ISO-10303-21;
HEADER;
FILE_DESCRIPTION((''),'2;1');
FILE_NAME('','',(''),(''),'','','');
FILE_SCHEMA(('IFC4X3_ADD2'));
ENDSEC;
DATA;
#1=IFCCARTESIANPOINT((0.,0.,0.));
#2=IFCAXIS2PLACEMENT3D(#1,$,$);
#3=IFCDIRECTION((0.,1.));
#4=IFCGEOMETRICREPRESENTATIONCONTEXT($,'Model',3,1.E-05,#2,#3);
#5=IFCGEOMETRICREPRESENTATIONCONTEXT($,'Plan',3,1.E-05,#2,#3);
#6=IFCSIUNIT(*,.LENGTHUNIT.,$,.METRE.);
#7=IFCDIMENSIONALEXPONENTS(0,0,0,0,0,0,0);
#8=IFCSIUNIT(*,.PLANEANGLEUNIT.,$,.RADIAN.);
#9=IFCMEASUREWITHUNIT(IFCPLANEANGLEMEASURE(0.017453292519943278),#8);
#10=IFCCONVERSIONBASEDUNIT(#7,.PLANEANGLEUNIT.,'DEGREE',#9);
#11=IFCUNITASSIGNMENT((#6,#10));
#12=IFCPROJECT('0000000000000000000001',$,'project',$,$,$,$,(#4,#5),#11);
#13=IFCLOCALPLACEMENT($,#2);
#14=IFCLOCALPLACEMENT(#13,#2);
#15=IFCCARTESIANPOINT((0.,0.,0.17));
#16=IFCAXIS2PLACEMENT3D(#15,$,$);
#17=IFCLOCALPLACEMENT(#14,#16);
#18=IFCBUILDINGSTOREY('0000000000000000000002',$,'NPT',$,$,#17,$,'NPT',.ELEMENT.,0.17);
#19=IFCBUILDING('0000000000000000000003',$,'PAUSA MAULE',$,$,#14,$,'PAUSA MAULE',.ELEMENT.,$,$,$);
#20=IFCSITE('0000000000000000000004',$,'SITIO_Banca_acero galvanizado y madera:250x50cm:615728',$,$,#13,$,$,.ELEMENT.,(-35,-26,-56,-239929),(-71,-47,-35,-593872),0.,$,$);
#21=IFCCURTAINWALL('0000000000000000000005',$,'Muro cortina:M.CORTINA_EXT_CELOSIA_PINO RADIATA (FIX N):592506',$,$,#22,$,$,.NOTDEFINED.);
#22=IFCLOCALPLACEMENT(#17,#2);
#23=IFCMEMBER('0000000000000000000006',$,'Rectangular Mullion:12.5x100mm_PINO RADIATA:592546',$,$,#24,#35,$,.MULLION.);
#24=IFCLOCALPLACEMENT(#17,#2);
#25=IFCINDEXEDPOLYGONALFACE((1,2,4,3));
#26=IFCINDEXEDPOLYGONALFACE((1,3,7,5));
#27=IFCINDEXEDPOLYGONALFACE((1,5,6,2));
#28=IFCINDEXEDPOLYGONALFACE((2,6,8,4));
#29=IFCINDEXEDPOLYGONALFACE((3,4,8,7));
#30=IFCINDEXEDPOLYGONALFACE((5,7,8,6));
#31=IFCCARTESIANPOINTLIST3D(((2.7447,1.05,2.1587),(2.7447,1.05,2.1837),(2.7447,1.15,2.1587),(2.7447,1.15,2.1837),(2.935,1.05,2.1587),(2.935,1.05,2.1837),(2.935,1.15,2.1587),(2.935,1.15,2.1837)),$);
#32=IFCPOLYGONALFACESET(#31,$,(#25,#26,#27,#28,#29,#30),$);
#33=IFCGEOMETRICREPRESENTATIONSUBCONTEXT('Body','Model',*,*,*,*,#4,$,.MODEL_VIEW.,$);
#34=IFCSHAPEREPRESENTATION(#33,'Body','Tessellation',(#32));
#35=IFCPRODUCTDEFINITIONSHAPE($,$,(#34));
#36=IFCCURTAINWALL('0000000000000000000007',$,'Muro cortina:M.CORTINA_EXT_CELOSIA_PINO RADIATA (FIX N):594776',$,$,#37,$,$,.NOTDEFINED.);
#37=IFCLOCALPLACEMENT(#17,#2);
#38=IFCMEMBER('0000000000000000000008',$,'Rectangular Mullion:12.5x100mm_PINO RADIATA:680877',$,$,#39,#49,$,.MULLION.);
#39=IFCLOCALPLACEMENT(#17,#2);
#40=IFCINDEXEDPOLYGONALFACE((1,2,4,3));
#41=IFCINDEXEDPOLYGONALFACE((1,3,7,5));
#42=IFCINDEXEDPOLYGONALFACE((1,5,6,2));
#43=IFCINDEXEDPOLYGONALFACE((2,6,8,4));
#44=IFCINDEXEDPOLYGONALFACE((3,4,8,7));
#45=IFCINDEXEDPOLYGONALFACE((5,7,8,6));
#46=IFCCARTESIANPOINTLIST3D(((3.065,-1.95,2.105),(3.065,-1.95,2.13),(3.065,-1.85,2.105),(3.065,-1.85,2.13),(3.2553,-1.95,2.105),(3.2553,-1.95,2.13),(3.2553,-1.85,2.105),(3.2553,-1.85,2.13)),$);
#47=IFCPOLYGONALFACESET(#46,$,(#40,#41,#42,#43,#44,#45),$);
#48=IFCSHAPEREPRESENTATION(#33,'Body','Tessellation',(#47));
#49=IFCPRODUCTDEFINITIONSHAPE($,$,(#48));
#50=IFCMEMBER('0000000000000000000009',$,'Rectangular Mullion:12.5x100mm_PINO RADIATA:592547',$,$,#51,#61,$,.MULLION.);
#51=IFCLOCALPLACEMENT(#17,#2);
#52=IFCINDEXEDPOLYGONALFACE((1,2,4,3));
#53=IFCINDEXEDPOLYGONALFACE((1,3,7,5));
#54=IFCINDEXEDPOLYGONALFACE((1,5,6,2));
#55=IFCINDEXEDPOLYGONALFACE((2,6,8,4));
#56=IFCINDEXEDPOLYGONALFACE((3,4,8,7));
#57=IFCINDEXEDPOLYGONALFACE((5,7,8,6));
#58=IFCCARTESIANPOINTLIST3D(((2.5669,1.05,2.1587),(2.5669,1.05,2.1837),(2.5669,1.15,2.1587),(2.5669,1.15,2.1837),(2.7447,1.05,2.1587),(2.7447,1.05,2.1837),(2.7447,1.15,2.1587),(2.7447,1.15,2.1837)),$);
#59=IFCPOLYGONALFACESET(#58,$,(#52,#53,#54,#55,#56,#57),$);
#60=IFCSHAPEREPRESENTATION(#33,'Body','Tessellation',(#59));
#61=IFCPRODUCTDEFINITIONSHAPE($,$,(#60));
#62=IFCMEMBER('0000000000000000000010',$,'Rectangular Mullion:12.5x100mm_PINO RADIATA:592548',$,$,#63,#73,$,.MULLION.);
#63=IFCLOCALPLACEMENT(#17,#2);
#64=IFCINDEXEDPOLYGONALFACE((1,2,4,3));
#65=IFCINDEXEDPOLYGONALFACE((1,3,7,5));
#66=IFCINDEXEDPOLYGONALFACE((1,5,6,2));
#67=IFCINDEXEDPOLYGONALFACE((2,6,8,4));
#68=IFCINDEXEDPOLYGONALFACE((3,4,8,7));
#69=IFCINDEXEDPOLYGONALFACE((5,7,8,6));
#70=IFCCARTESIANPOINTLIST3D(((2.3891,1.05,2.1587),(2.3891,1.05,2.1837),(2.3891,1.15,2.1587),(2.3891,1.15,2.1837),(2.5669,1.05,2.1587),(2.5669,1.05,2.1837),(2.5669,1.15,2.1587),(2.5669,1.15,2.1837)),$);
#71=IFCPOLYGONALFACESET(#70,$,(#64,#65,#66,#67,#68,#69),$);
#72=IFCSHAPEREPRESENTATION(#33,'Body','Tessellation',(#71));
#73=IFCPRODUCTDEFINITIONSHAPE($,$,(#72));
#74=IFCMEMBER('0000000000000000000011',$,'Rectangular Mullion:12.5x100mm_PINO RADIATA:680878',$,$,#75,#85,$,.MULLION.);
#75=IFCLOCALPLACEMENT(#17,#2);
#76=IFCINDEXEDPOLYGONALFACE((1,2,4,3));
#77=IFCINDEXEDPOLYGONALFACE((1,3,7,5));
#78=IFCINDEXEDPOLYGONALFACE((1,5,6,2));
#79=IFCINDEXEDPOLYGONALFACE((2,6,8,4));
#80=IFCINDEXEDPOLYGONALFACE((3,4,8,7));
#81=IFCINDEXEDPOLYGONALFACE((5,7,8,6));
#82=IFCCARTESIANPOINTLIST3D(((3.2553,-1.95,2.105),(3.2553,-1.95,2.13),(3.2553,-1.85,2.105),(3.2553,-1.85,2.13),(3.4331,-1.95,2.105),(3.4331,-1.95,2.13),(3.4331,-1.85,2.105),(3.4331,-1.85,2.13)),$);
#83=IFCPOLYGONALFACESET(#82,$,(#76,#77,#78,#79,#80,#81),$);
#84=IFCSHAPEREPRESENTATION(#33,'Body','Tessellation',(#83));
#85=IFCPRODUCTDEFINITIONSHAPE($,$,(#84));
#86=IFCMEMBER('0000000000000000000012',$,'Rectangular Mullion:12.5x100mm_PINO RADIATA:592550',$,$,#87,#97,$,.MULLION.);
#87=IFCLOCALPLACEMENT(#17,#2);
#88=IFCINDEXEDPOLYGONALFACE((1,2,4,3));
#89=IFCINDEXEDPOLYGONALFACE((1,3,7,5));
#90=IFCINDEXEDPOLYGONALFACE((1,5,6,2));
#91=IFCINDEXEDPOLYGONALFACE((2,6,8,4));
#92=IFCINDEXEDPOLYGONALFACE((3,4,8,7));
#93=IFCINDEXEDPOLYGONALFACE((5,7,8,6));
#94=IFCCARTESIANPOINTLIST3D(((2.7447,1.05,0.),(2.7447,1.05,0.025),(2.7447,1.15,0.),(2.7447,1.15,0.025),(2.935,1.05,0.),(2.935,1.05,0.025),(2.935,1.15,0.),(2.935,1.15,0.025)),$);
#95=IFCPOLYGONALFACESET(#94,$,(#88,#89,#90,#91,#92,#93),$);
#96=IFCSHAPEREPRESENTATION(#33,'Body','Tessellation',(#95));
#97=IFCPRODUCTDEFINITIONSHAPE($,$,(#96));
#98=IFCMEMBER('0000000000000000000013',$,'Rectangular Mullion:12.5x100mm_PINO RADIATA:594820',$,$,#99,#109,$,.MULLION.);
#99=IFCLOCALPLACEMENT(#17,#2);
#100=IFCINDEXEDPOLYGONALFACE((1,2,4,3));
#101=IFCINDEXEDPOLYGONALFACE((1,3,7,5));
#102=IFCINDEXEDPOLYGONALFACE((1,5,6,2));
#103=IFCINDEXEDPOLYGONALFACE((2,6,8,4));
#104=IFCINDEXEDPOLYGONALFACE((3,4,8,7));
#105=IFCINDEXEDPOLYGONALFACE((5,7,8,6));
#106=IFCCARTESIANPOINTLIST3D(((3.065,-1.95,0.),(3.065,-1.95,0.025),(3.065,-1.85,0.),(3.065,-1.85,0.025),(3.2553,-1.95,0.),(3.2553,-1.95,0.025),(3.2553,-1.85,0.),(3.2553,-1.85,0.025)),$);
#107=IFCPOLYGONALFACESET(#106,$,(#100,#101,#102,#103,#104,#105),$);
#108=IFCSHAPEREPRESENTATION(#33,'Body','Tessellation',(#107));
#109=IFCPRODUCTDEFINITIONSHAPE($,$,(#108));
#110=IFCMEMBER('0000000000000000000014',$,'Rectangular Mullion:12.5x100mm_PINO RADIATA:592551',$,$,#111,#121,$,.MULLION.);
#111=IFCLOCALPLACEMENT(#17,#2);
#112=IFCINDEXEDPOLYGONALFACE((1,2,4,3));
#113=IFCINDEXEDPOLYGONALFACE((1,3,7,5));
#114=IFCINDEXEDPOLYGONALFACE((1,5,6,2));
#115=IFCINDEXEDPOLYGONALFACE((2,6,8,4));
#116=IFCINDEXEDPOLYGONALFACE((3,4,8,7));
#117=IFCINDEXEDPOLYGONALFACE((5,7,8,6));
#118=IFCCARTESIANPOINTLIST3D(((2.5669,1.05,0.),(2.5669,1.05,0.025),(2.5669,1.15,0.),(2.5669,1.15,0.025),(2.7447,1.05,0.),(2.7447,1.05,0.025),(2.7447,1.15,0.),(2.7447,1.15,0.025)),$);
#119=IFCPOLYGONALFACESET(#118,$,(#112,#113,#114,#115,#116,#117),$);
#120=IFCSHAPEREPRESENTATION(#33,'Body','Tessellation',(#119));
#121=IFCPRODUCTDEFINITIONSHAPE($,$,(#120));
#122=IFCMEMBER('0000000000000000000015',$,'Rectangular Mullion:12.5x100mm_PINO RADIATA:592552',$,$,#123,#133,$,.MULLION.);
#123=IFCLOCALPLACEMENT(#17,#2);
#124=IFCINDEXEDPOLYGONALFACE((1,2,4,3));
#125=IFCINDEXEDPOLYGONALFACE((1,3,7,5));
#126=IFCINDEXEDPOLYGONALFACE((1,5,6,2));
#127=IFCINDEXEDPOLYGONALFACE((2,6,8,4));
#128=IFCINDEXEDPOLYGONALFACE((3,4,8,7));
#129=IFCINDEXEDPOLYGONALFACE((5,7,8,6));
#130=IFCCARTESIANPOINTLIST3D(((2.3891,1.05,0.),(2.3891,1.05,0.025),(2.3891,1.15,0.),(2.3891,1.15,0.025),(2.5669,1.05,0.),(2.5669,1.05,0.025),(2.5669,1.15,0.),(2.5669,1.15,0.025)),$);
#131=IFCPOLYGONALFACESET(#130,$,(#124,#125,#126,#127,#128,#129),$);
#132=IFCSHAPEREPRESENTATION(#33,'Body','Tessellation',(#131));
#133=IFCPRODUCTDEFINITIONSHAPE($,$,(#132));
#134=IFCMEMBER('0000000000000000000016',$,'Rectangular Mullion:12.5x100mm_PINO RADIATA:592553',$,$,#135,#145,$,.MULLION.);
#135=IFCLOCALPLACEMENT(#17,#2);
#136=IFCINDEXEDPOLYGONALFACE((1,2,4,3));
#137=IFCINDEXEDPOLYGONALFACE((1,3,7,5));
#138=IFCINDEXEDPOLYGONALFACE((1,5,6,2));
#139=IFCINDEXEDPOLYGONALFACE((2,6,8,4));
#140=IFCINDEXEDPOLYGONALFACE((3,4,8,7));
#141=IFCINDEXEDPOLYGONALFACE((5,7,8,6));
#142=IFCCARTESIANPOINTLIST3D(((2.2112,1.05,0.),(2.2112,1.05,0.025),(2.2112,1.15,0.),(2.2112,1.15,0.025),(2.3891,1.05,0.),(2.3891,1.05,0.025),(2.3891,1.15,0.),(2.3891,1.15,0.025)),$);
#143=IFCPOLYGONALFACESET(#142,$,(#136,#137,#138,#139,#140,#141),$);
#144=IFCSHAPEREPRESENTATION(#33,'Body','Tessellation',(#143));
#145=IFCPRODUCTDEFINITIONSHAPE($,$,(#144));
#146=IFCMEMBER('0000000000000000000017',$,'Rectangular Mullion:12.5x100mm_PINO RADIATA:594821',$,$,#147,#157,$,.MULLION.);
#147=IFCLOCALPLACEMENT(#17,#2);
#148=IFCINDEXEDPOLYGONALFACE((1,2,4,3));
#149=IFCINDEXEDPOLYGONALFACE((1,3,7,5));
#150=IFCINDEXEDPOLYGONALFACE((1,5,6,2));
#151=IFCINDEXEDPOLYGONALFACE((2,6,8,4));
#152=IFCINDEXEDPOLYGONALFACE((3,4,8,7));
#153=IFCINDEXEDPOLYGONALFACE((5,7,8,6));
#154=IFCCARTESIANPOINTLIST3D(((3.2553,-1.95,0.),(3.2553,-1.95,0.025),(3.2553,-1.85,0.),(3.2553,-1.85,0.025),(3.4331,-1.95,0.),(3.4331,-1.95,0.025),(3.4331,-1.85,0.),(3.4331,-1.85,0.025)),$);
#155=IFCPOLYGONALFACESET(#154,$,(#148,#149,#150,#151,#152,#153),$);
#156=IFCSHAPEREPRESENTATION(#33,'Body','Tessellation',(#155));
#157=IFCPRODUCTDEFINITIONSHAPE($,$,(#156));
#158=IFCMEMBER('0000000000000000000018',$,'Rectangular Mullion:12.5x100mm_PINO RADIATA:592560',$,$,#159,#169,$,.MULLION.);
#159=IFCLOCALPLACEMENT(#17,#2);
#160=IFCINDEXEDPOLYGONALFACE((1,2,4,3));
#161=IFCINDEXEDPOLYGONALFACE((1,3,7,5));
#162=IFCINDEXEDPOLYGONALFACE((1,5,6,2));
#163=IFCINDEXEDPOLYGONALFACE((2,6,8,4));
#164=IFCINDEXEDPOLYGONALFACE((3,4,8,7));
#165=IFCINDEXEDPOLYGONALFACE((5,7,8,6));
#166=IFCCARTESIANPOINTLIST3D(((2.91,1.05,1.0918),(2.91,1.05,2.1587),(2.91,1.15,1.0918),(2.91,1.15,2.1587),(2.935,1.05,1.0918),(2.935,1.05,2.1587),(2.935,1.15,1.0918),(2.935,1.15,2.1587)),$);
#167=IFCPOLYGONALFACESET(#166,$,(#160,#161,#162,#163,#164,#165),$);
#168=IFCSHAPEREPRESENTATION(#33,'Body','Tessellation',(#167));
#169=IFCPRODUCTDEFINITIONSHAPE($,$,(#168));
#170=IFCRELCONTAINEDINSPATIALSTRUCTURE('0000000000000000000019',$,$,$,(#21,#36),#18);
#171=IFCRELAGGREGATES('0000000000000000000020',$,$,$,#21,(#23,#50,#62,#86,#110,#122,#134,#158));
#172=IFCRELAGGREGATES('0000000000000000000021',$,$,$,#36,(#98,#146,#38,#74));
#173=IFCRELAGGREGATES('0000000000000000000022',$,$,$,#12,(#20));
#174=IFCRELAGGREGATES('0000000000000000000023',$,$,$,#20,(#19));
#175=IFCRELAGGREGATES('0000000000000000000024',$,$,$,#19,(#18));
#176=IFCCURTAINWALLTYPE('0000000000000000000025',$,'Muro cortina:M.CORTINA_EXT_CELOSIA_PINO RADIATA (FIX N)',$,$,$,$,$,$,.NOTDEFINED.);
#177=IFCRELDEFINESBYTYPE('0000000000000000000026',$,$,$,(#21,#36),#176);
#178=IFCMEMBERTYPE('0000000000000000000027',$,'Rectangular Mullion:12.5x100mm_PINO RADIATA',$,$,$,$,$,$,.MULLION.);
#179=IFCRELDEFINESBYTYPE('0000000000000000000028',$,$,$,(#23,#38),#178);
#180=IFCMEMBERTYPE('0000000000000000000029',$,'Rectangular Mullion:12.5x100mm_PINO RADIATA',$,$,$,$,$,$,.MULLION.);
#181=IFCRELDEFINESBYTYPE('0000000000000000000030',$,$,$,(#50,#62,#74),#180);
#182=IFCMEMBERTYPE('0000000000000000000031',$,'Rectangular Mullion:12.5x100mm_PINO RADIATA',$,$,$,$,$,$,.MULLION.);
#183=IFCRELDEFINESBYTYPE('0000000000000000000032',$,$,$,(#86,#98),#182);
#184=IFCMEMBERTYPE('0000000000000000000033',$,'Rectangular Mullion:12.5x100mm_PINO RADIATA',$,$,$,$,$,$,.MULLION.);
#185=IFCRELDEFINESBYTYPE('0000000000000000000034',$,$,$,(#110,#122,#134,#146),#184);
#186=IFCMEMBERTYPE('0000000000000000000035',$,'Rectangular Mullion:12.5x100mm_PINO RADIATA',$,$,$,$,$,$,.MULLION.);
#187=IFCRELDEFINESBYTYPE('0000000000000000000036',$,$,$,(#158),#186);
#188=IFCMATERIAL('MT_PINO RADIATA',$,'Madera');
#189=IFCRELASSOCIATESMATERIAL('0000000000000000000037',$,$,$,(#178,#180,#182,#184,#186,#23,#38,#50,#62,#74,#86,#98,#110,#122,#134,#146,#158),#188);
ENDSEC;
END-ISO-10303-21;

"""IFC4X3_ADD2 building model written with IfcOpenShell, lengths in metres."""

from ifc_helpers import new_model, entity, si_unit, converted_unit, direction, frame, frame_2d, origin, place, context, subcontext, project, spatial, rectangle, extrude, source, transform, mapped, material, material_profile, profile_set, profile_usage, type_object, type_shapes, element, aggregate, save


model = new_model("IFC4X3_ADD2")

# Units and contexts
model_context = context("Model", 3, precision=1e-05, world=origin(), true_north=direction((0.0, 1.0)))
plan_context = context("Plan", 3, precision=1e-05, world=origin(), true_north=direction((0.0, 1.0)))
body_context = subcontext(model_context, "Body", "Model", "MODEL_VIEW")
ifc_project = project(units=[si_unit("LENGTHUNIT", "METRE"), converted_unit("PLANEANGLEUNIT", "DEGREE", entity("IfcPlaneAngleMeasure", 0.017453292519943278), si_unit("PLANEANGLEUNIT", "RADIAN"), dimensions=[0, 0, 0, 0, 0, 0, 0])], contexts=[model_context, plan_context])

# Site, building, storey
site_placement = place(None, origin())
site = spatial("IfcSite", under=ifc_project, at=site_placement, Name="SITIO_Banca_acero galvanizado y madera:250x50cm:615728", CompositionType="ELEMENT", RefLatitude=(-35, -26, -56, -239929), RefLongitude=(-71, -47, -35, -593872), RefElevation=0.0)
building_placement = place(site_placement, origin())
building = spatial("IfcBuilding", under=site, at=building_placement, Name="PAUSA MAULE", LongName="PAUSA MAULE", CompositionType="ELEMENT")
storey_placement = place(building_placement, frame((0.0, 0.0, 0.17)))
storey = spatial("IfcBuildingStorey", under=building, at=storey_placement, Name="NPT", LongName="NPT", CompositionType="ELEMENT", Elevation=0.17)

# Curtain walls, members
curtain_wall_type = type_object("IfcCurtainWallType", Name="Muro cortina:M.CORTINA_EXT_CELOSIA_PINO RADIATA (FIX N)", PredefinedType="NOTDEFINED")
curtain_wall_1_placement = place(storey_placement, frame((0.0, 0.0, -0.17)))
curtain_wall_1 = element("IfcCurtainWall", 1, at=curtain_wall_1_placement, inside=storey, type_object=curtain_wall_type, Name="Muro cortina:M.CORTINA_EXT_CELOSIA_PINO RADIATA (FIX N):592506", PredefinedType="NOTDEFINED")
ifc_material = material(Name="MT_PINO RADIATA", Category="Madera")
ifc_material_profile = material_profile(ifc_material, rectangle(XDim=0.025, YDim=0.1, at=frame_2d((0.0, 0.0), x_axis=(1.0, 0.0))), Name="12.5x100mm_PINO RADIATA")
ifc_profile_set = profile_set([ifc_material_profile], Name="12.5x100mm_PINO RADIATA")
ifc_profile_usage = profile_usage(ifc_profile_set)
member_type_1 = type_object("IfcMemberType", Name="Rectangular Mullion:12.5x100mm_PINO RADIATA", PredefinedType="MULLION", material=ifc_profile_set)
shared_shape_1 = source(origin(), body_context, "Body", "SweptSolid", [
    extrude(rectangle(XDim=0.025, YDim=0.1, at=frame_2d((0.0, 0.0), x_axis=(1.0, 0.0))), frame((-0.0125, 0.0, -0.1903), z_axis=(0.0, 0.0, 1.0), x_axis=(-1.0, 0.0, 0.0)), (0.0, 0.0, 1.0), 0.1903),
])
type_shapes(member_type_1, [shared_shape_1])
member_1_placement = place(curtain_wall_1_placement, frame((2.7447, 1.1, 2.3537), z_axis=(-1.0, 0.0, 0.0), x_axis=(0.0, 0.0, 1.0)))
member_1 = element("IfcMember", 2, at=member_1_placement, type_object=member_type_1, material=ifc_profile_usage, Name="Rectangular Mullion:12.5x100mm_PINO RADIATA:592546", PredefinedType="MULLION", context=body_context, shape_type="MappedRepresentation", body=[
    mapped(shared_shape_1, transform((0.0, 0.0, 0.0), scale=1.0)),
])
curtain_wall_2_placement = place(storey_placement, frame((0.0, 0.0, -0.17)))
curtain_wall_2 = element("IfcCurtainWall", 3, at=curtain_wall_2_placement, inside=storey, type_object=curtain_wall_type, Name="Muro cortina:M.CORTINA_EXT_CELOSIA_PINO RADIATA (FIX N):594776", PredefinedType="NOTDEFINED")
member_2_placement = place(curtain_wall_2_placement, frame((3.2553, -1.9, 2.3), z_axis=(1.0, 0.0, 0.0), x_axis=(0.0, 0.0, 1.0)))
member_2 = element("IfcMember", 4, at=member_2_placement, type_object=member_type_1, material=ifc_profile_usage, Name="Rectangular Mullion:12.5x100mm_PINO RADIATA:680877", PredefinedType="MULLION", context=body_context, shape_type="MappedRepresentation", body=[
    mapped(shared_shape_1, transform((0.0, 0.0, 0.0), scale=1.0)),
])

# Members
member_type_2 = type_object("IfcMemberType", Name="Rectangular Mullion:12.5x100mm_PINO RADIATA", PredefinedType="MULLION", material=ifc_profile_set)
shared_shape_2 = source(origin(), body_context, "Body", "SweptSolid", [
    extrude(rectangle(XDim=0.025, YDim=0.1, at=frame_2d((0.0, 0.0), x_axis=(1.0, 0.0))), frame((-0.0125, 0.0, -0.1778), z_axis=(0.0, 0.0, 1.0), x_axis=(-1.0, 0.0, 0.0)), (0.0, 0.0, 1.0), 0.1778),
])
type_shapes(member_type_2, [shared_shape_2])
member_3_placement = place(curtain_wall_1_placement, frame((2.5669, 1.1, 2.3537), z_axis=(-1.0, 0.0, 0.0), x_axis=(0.0, 0.0, 1.0)))
member_3 = element("IfcMember", 5, at=member_3_placement, type_object=member_type_2, material=ifc_profile_usage, Name="Rectangular Mullion:12.5x100mm_PINO RADIATA:592547", PredefinedType="MULLION", context=body_context, shape_type="MappedRepresentation", body=[
    mapped(shared_shape_2, transform((0.0, 0.0, 0.0), scale=1.0)),
])
member_4_placement = place(curtain_wall_1_placement, frame((2.3891, 1.1, 2.3537), z_axis=(-1.0, 0.0, 0.0), x_axis=(0.0, 0.0, 1.0)))
member_4 = element("IfcMember", 6, at=member_4_placement, type_object=member_type_2, material=ifc_profile_usage, Name="Rectangular Mullion:12.5x100mm_PINO RADIATA:592548", PredefinedType="MULLION", context=body_context, shape_type="MappedRepresentation", body=[
    mapped(shared_shape_2, transform((0.0, 0.0, 0.0), scale=1.0)),
])
member_5_placement = place(curtain_wall_2_placement, frame((3.4331, -1.9, 2.3), z_axis=(1.0, 0.0, 0.0), x_axis=(0.0, 0.0, 1.0)))
member_5 = element("IfcMember", 7, at=member_5_placement, type_object=member_type_2, material=ifc_profile_usage, Name="Rectangular Mullion:12.5x100mm_PINO RADIATA:680878", PredefinedType="MULLION", context=body_context, shape_type="MappedRepresentation", body=[
    mapped(shared_shape_2, transform((0.0, 0.0, 0.0), scale=1.0)),
])
member_type_3 = type_object("IfcMemberType", Name="Rectangular Mullion:12.5x100mm_PINO RADIATA", PredefinedType="MULLION", material=ifc_profile_set)
shared_shape_3 = source(origin(), body_context, "Body", "SweptSolid", [
    extrude(rectangle(XDim=0.025, YDim=0.1, at=frame_2d((0.0, 0.0), x_axis=(1.0, 0.0))), frame((-0.0125, 0.0, -0.1903), z_axis=(0.0, 0.0, 1.0), x_axis=(-1.0, 0.0, 0.0)), (0.0, 0.0, 1.0), 0.1903),
])
type_shapes(member_type_3, [shared_shape_3])
member_6_placement = place(curtain_wall_1_placement, frame((2.935, 1.1, 0.17), z_axis=(1.0, 0.0, 0.0), x_axis=(0.0, 0.0, -1.0)))
member_6 = element("IfcMember", 8, at=member_6_placement, type_object=member_type_3, material=ifc_profile_usage, Name="Rectangular Mullion:12.5x100mm_PINO RADIATA:592550", PredefinedType="MULLION", context=body_context, shape_type="MappedRepresentation", body=[
    mapped(shared_shape_3, transform((0.0, 0.0, 0.0), scale=1.0)),
])
member_7_placement = place(curtain_wall_2_placement, frame((3.065, -1.9, 0.17), z_axis=(-1.0, 0.0, 0.0), x_axis=(0.0, 0.0, -1.0)))
member_7 = element("IfcMember", 9, at=member_7_placement, type_object=member_type_3, material=ifc_profile_usage, Name="Rectangular Mullion:12.5x100mm_PINO RADIATA:594820", PredefinedType="MULLION", context=body_context, shape_type="MappedRepresentation", body=[
    mapped(shared_shape_3, transform((0.0, 0.0, 0.0), scale=1.0)),
])
member_type_4 = type_object("IfcMemberType", Name="Rectangular Mullion:12.5x100mm_PINO RADIATA", PredefinedType="MULLION", material=ifc_profile_set)
shared_shape_4 = source(origin(), body_context, "Body", "SweptSolid", [
    extrude(rectangle(XDim=0.025, YDim=0.1, at=frame_2d((0.0, 0.0), x_axis=(1.0, 0.0))), frame((-0.0125, 0.0, -0.1778), z_axis=(0.0, 0.0, 1.0), x_axis=(-1.0, 0.0, 0.0)), (0.0, 0.0, 1.0), 0.1778),
])
type_shapes(member_type_4, [shared_shape_4])
member_8_placement = place(curtain_wall_1_placement, frame((2.7447, 1.1, 0.17), z_axis=(1.0, 0.0, 0.0), x_axis=(0.0, 0.0, -1.0)))
member_8 = element("IfcMember", 10, at=member_8_placement, type_object=member_type_4, material=ifc_profile_usage, Name="Rectangular Mullion:12.5x100mm_PINO RADIATA:592551", PredefinedType="MULLION", context=body_context, shape_type="MappedRepresentation", body=[
    mapped(shared_shape_4, transform((0.0, 0.0, 0.0), scale=1.0)),
])
member_9_placement = place(curtain_wall_1_placement, frame((2.5669, 1.1, 0.17), z_axis=(1.0, 0.0, 0.0), x_axis=(0.0, 0.0, -1.0)))
member_9 = element("IfcMember", 11, at=member_9_placement, type_object=member_type_4, material=ifc_profile_usage, Name="Rectangular Mullion:12.5x100mm_PINO RADIATA:592552", PredefinedType="MULLION", context=body_context, shape_type="MappedRepresentation", body=[
    mapped(shared_shape_4, transform((0.0, 0.0, 0.0), scale=1.0)),
])
member_10_placement = place(curtain_wall_1_placement, frame((2.3891, 1.1, 0.17), z_axis=(1.0, 0.0, 0.0), x_axis=(0.0, 0.0, -1.0)))
member_10 = element("IfcMember", 12, at=member_10_placement, type_object=member_type_4, material=ifc_profile_usage, Name="Rectangular Mullion:12.5x100mm_PINO RADIATA:592553", PredefinedType="MULLION", context=body_context, shape_type="MappedRepresentation", body=[
    mapped(shared_shape_4, transform((0.0, 0.0, 0.0), scale=1.0)),
])
member_11_placement = place(curtain_wall_2_placement, frame((3.2553, -1.9, 0.17), z_axis=(-1.0, 0.0, 0.0), x_axis=(0.0, 0.0, -1.0)))
member_11 = element("IfcMember", 13, at=member_11_placement, type_object=member_type_4, material=ifc_profile_usage, Name="Rectangular Mullion:12.5x100mm_PINO RADIATA:594821", PredefinedType="MULLION", context=body_context, shape_type="MappedRepresentation", body=[
    mapped(shared_shape_4, transform((0.0, 0.0, 0.0), scale=1.0)),
])
member_type_5 = type_object("IfcMemberType", Name="Rectangular Mullion:12.5x100mm_PINO RADIATA", PredefinedType="MULLION", material=ifc_profile_set)
shared_shape_5 = source(origin(), body_context, "Body", "SweptSolid", [
    extrude(rectangle(XDim=0.025, YDim=0.1, at=frame_2d((0.0, 0.0), x_axis=(1.0, 0.0))), frame((-0.0125, 0.0, -1.0668), z_axis=(0.0, 0.0, 1.0), x_axis=(-1.0, 0.0, 0.0)), (0.0, 0.0, 1.0), 1.0668),
])
type_shapes(member_type_5, [shared_shape_5])
member_12_placement = place(curtain_wall_1_placement, frame((2.935, 1.1, 2.3287)))
member_12 = element("IfcMember", 14, at=member_12_placement, type_object=member_type_5, material=ifc_profile_usage, Name="Rectangular Mullion:12.5x100mm_PINO RADIATA:592560", PredefinedType="MULLION", context=body_context, shape_type="MappedRepresentation", body=[
    mapped(shared_shape_5, transform((0.0, 0.0, 0.0), scale=1.0)),
])
aggregate(curtain_wall_1, [member_1, member_3, member_4, member_6, member_8, member_9, member_10, member_12])
aggregate(curtain_wall_2, [member_7, member_11, member_2, member_5])

save(model, "model.ifc")
